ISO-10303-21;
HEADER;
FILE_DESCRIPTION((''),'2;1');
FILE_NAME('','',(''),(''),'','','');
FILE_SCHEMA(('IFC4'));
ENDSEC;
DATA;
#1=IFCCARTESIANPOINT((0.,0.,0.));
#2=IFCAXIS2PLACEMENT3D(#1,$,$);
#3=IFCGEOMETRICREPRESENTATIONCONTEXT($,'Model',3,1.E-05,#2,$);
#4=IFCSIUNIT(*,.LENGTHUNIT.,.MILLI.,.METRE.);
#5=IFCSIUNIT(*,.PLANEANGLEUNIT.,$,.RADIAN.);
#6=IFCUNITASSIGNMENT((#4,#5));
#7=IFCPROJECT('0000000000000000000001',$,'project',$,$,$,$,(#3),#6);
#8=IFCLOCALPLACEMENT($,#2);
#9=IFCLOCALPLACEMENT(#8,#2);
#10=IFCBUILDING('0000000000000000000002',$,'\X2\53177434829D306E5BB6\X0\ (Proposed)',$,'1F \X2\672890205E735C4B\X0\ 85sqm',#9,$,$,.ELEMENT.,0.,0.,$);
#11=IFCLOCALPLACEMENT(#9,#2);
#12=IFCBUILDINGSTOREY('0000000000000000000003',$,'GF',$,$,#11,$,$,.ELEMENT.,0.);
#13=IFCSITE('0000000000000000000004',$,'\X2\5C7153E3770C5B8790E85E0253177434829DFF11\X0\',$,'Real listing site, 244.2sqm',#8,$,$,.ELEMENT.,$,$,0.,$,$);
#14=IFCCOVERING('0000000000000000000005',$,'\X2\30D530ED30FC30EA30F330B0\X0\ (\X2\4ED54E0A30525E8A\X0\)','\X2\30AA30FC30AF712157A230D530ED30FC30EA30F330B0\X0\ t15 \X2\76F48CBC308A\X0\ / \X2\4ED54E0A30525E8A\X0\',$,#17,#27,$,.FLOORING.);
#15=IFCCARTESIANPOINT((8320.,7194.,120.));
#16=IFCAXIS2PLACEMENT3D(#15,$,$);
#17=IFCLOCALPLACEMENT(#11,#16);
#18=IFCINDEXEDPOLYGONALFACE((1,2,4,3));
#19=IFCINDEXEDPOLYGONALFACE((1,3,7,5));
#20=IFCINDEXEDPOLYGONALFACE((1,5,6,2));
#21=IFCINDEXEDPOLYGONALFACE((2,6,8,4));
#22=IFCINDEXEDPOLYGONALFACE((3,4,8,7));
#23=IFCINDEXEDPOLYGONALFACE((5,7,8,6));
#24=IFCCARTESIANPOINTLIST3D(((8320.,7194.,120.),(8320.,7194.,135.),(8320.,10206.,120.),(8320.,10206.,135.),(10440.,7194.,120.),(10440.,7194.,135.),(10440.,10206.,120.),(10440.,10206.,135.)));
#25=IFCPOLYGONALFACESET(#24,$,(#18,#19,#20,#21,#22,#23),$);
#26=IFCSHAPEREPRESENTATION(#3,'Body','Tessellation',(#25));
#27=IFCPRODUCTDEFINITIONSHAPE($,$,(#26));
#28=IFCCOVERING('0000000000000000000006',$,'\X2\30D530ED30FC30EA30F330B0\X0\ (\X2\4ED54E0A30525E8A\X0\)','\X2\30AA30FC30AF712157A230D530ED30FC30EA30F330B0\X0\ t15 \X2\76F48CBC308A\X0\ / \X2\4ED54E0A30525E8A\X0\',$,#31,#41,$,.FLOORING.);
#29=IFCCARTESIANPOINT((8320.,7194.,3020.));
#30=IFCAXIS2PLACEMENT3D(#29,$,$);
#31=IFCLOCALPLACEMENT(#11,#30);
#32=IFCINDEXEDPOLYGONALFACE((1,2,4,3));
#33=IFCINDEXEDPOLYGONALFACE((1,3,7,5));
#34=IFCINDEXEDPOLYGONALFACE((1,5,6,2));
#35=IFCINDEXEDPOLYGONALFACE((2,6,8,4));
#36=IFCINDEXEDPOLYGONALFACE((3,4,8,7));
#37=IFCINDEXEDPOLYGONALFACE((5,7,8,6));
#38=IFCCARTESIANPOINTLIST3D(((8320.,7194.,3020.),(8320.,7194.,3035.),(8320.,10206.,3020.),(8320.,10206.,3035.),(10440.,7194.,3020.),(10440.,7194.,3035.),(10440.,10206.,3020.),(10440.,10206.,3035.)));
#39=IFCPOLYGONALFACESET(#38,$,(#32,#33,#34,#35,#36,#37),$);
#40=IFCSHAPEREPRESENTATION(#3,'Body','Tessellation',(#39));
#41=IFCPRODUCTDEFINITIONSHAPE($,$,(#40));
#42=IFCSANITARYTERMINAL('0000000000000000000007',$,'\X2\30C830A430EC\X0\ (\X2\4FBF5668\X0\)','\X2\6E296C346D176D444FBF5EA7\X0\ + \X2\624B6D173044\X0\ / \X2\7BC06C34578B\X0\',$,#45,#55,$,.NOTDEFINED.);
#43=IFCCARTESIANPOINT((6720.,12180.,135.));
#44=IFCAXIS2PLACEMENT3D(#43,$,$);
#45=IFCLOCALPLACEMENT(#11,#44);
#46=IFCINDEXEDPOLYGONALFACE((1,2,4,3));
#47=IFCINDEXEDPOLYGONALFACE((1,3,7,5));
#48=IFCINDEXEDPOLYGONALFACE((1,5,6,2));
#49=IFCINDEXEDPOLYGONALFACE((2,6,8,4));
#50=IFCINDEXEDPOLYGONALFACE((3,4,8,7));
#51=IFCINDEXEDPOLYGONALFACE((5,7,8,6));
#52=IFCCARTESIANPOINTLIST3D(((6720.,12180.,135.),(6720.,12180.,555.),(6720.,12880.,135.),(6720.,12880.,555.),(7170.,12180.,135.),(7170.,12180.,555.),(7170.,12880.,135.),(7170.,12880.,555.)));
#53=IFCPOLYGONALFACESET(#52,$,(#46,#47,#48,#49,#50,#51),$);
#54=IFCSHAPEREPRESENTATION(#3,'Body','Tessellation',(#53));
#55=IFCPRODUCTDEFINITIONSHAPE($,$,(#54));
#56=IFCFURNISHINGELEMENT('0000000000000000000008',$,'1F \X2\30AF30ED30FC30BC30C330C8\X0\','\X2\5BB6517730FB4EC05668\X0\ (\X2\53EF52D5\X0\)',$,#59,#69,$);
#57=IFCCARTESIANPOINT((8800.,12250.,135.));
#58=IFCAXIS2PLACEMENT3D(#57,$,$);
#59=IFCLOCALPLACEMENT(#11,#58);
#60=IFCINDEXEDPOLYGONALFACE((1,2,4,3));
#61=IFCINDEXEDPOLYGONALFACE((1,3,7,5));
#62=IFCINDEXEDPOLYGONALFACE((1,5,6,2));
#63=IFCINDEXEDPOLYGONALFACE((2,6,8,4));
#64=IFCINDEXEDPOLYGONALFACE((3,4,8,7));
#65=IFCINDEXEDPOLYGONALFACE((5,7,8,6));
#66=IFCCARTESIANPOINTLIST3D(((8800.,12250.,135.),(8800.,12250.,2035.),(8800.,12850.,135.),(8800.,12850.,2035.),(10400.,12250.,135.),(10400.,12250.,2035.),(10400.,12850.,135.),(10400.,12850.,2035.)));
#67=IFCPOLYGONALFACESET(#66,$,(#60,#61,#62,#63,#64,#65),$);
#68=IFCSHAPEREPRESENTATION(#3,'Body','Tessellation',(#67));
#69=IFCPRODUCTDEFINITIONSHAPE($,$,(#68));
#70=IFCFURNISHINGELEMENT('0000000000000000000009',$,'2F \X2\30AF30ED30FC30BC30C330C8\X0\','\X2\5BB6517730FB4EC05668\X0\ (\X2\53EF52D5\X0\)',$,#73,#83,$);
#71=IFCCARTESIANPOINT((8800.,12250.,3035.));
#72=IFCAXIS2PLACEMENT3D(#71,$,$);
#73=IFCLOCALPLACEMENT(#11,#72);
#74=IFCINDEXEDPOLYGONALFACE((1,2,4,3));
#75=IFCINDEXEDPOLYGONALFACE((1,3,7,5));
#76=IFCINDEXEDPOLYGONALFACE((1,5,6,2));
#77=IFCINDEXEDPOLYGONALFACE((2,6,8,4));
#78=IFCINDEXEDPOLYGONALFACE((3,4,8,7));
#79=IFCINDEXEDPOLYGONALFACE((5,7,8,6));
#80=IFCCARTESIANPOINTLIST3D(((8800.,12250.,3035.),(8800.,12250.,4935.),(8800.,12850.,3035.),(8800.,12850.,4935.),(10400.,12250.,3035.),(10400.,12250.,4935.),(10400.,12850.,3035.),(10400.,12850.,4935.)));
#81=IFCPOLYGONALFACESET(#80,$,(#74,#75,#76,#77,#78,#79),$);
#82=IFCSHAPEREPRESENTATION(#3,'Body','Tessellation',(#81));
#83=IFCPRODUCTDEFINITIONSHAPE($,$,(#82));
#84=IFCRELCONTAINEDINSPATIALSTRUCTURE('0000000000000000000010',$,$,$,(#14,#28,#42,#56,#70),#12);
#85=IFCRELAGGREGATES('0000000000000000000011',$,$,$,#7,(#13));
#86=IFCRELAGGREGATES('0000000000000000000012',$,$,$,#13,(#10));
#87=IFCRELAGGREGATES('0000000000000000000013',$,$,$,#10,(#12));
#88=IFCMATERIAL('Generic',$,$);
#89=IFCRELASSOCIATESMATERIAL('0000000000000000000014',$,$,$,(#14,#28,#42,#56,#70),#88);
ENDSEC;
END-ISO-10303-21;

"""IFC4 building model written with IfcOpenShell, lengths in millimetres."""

from ifc_helpers import new_model, si_unit, frame, frame_2d, origin, place, context, project, spatial, rectangle, extrude, material, element, save


model = new_model("IFC4")

# Units and contexts
model_context = context("Model", 3, precision=1e-05, world=origin())
ifc_project = project(units=[si_unit("LENGTHUNIT", "METRE", prefix="MILLI"), si_unit("PLANEANGLEUNIT", "RADIAN")], contexts=[model_context])

# Site, building, storey
site_placement = place(None, origin())
site = spatial("IfcSite", under=ifc_project, at=site_placement, Name="山口県宇部市北琴芝１", ObjectType="Real listing site, 244.2sqm", CompositionType="ELEMENT", RefElevation=0.0)
building_placement = place(site_placement, origin())
building = spatial("IfcBuilding", under=site, at=building_placement, Name="北琴芝の家 (Proposed)", ObjectType="1F 木造平屋 85sqm", CompositionType="ELEMENT", ElevationOfRefHeight=0.0, ElevationOfTerrain=0.0)
storey_placement = place(building_placement, origin())
storey = spatial("IfcBuildingStorey", under=building, at=storey_placement, Name="GF", CompositionType="ELEMENT", Elevation=0.0)

# Shared definitions
ifc_material_1 = material(Name="Generic")

# Coverings
covering_1_placement = place(storey_placement, frame((8320.0, 7194.0, 120.0)))
element("IfcCovering", 1, at=covering_1_placement, inside=storey, material=ifc_material_1, Name="フローリング (仕上げ床)", Description="オーク無垢フローリング t15 直貼り / 仕上げ床", PredefinedType="FLOORING", context=model_context, shape_type="SweptSolid", body=[
    extrude(rectangle(XDim=2120.0, YDim=3012.0, at=frame_2d((1060.0, 1506.0))), frame((8320.0, 7194.0, 120.0)), (0.0, 0.0, 1.0), 15.0),
])
covering_2_placement = place(storey_placement, frame((8320.0, 7194.0, 3020.0)))
element("IfcCovering", 2, at=covering_2_placement, inside=storey, material=ifc_material_1, Name="フローリング (仕上げ床)", Description="オーク無垢フローリング t15 直貼り / 仕上げ床", PredefinedType="FLOORING", context=model_context, shape_type="SweptSolid", body=[
    extrude(rectangle(XDim=2120.0, YDim=3012.0, at=frame_2d((1060.0, 1506.0))), frame((8320.0, 7194.0, 3020.0)), (0.0, 0.0, 1.0), 15.0),
])

# Sanitary terminal
sanitary_terminal_placement = place(storey_placement, frame((6720.0, 12180.0, 135.0)))
element("IfcSanitaryTerminal", 3, at=sanitary_terminal_placement, inside=storey, material=ifc_material_1, Name="トイレ (便器)", Description="温水洗浄便座 + 手洗い / 節水型", PredefinedType="NOTDEFINED", context=model_context, shape_type="SweptSolid", body=[
    extrude(rectangle(XDim=450.0, YDim=700.0, at=frame_2d((225.0, 350.0))), frame((6720.0, 12180.0, 135.0)), (0.0, 0.0, 1.0), 420.0),
])

# Furnishing elements
furnishing_1_placement = place(storey_placement, frame((8800.0, 12250.0, 135.0)))
element("IfcFurnishingElement", 4, at=furnishing_1_placement, inside=storey, material=ifc_material_1, Name="1F クローゼット", Description="家具・什器 (可動)", context=model_context, shape_type="SweptSolid", body=[
    extrude(rectangle(XDim=1600.0, YDim=600.0, at=frame_2d((800.0, 300.0))), frame((8800.0, 12250.0, 135.0)), (0.0, 0.0, 1.0), 1900.0),
])
furnishing_2_placement = place(storey_placement, frame((8800.0, 12250.0, 3035.0)))
element("IfcFurnishingElement", 5, at=furnishing_2_placement, inside=storey, material=ifc_material_1, Name="2F クローゼット", Description="家具・什器 (可動)", context=model_context, shape_type="SweptSolid", body=[
    extrude(rectangle(XDim=1600.0, YDim=600.0, at=frame_2d((800.0, 300.0))), frame((8800.0, 12250.0, 3035.0)), (0.0, 0.0, 1.0), 1900.0),
])

save(model, "model.ifc")
